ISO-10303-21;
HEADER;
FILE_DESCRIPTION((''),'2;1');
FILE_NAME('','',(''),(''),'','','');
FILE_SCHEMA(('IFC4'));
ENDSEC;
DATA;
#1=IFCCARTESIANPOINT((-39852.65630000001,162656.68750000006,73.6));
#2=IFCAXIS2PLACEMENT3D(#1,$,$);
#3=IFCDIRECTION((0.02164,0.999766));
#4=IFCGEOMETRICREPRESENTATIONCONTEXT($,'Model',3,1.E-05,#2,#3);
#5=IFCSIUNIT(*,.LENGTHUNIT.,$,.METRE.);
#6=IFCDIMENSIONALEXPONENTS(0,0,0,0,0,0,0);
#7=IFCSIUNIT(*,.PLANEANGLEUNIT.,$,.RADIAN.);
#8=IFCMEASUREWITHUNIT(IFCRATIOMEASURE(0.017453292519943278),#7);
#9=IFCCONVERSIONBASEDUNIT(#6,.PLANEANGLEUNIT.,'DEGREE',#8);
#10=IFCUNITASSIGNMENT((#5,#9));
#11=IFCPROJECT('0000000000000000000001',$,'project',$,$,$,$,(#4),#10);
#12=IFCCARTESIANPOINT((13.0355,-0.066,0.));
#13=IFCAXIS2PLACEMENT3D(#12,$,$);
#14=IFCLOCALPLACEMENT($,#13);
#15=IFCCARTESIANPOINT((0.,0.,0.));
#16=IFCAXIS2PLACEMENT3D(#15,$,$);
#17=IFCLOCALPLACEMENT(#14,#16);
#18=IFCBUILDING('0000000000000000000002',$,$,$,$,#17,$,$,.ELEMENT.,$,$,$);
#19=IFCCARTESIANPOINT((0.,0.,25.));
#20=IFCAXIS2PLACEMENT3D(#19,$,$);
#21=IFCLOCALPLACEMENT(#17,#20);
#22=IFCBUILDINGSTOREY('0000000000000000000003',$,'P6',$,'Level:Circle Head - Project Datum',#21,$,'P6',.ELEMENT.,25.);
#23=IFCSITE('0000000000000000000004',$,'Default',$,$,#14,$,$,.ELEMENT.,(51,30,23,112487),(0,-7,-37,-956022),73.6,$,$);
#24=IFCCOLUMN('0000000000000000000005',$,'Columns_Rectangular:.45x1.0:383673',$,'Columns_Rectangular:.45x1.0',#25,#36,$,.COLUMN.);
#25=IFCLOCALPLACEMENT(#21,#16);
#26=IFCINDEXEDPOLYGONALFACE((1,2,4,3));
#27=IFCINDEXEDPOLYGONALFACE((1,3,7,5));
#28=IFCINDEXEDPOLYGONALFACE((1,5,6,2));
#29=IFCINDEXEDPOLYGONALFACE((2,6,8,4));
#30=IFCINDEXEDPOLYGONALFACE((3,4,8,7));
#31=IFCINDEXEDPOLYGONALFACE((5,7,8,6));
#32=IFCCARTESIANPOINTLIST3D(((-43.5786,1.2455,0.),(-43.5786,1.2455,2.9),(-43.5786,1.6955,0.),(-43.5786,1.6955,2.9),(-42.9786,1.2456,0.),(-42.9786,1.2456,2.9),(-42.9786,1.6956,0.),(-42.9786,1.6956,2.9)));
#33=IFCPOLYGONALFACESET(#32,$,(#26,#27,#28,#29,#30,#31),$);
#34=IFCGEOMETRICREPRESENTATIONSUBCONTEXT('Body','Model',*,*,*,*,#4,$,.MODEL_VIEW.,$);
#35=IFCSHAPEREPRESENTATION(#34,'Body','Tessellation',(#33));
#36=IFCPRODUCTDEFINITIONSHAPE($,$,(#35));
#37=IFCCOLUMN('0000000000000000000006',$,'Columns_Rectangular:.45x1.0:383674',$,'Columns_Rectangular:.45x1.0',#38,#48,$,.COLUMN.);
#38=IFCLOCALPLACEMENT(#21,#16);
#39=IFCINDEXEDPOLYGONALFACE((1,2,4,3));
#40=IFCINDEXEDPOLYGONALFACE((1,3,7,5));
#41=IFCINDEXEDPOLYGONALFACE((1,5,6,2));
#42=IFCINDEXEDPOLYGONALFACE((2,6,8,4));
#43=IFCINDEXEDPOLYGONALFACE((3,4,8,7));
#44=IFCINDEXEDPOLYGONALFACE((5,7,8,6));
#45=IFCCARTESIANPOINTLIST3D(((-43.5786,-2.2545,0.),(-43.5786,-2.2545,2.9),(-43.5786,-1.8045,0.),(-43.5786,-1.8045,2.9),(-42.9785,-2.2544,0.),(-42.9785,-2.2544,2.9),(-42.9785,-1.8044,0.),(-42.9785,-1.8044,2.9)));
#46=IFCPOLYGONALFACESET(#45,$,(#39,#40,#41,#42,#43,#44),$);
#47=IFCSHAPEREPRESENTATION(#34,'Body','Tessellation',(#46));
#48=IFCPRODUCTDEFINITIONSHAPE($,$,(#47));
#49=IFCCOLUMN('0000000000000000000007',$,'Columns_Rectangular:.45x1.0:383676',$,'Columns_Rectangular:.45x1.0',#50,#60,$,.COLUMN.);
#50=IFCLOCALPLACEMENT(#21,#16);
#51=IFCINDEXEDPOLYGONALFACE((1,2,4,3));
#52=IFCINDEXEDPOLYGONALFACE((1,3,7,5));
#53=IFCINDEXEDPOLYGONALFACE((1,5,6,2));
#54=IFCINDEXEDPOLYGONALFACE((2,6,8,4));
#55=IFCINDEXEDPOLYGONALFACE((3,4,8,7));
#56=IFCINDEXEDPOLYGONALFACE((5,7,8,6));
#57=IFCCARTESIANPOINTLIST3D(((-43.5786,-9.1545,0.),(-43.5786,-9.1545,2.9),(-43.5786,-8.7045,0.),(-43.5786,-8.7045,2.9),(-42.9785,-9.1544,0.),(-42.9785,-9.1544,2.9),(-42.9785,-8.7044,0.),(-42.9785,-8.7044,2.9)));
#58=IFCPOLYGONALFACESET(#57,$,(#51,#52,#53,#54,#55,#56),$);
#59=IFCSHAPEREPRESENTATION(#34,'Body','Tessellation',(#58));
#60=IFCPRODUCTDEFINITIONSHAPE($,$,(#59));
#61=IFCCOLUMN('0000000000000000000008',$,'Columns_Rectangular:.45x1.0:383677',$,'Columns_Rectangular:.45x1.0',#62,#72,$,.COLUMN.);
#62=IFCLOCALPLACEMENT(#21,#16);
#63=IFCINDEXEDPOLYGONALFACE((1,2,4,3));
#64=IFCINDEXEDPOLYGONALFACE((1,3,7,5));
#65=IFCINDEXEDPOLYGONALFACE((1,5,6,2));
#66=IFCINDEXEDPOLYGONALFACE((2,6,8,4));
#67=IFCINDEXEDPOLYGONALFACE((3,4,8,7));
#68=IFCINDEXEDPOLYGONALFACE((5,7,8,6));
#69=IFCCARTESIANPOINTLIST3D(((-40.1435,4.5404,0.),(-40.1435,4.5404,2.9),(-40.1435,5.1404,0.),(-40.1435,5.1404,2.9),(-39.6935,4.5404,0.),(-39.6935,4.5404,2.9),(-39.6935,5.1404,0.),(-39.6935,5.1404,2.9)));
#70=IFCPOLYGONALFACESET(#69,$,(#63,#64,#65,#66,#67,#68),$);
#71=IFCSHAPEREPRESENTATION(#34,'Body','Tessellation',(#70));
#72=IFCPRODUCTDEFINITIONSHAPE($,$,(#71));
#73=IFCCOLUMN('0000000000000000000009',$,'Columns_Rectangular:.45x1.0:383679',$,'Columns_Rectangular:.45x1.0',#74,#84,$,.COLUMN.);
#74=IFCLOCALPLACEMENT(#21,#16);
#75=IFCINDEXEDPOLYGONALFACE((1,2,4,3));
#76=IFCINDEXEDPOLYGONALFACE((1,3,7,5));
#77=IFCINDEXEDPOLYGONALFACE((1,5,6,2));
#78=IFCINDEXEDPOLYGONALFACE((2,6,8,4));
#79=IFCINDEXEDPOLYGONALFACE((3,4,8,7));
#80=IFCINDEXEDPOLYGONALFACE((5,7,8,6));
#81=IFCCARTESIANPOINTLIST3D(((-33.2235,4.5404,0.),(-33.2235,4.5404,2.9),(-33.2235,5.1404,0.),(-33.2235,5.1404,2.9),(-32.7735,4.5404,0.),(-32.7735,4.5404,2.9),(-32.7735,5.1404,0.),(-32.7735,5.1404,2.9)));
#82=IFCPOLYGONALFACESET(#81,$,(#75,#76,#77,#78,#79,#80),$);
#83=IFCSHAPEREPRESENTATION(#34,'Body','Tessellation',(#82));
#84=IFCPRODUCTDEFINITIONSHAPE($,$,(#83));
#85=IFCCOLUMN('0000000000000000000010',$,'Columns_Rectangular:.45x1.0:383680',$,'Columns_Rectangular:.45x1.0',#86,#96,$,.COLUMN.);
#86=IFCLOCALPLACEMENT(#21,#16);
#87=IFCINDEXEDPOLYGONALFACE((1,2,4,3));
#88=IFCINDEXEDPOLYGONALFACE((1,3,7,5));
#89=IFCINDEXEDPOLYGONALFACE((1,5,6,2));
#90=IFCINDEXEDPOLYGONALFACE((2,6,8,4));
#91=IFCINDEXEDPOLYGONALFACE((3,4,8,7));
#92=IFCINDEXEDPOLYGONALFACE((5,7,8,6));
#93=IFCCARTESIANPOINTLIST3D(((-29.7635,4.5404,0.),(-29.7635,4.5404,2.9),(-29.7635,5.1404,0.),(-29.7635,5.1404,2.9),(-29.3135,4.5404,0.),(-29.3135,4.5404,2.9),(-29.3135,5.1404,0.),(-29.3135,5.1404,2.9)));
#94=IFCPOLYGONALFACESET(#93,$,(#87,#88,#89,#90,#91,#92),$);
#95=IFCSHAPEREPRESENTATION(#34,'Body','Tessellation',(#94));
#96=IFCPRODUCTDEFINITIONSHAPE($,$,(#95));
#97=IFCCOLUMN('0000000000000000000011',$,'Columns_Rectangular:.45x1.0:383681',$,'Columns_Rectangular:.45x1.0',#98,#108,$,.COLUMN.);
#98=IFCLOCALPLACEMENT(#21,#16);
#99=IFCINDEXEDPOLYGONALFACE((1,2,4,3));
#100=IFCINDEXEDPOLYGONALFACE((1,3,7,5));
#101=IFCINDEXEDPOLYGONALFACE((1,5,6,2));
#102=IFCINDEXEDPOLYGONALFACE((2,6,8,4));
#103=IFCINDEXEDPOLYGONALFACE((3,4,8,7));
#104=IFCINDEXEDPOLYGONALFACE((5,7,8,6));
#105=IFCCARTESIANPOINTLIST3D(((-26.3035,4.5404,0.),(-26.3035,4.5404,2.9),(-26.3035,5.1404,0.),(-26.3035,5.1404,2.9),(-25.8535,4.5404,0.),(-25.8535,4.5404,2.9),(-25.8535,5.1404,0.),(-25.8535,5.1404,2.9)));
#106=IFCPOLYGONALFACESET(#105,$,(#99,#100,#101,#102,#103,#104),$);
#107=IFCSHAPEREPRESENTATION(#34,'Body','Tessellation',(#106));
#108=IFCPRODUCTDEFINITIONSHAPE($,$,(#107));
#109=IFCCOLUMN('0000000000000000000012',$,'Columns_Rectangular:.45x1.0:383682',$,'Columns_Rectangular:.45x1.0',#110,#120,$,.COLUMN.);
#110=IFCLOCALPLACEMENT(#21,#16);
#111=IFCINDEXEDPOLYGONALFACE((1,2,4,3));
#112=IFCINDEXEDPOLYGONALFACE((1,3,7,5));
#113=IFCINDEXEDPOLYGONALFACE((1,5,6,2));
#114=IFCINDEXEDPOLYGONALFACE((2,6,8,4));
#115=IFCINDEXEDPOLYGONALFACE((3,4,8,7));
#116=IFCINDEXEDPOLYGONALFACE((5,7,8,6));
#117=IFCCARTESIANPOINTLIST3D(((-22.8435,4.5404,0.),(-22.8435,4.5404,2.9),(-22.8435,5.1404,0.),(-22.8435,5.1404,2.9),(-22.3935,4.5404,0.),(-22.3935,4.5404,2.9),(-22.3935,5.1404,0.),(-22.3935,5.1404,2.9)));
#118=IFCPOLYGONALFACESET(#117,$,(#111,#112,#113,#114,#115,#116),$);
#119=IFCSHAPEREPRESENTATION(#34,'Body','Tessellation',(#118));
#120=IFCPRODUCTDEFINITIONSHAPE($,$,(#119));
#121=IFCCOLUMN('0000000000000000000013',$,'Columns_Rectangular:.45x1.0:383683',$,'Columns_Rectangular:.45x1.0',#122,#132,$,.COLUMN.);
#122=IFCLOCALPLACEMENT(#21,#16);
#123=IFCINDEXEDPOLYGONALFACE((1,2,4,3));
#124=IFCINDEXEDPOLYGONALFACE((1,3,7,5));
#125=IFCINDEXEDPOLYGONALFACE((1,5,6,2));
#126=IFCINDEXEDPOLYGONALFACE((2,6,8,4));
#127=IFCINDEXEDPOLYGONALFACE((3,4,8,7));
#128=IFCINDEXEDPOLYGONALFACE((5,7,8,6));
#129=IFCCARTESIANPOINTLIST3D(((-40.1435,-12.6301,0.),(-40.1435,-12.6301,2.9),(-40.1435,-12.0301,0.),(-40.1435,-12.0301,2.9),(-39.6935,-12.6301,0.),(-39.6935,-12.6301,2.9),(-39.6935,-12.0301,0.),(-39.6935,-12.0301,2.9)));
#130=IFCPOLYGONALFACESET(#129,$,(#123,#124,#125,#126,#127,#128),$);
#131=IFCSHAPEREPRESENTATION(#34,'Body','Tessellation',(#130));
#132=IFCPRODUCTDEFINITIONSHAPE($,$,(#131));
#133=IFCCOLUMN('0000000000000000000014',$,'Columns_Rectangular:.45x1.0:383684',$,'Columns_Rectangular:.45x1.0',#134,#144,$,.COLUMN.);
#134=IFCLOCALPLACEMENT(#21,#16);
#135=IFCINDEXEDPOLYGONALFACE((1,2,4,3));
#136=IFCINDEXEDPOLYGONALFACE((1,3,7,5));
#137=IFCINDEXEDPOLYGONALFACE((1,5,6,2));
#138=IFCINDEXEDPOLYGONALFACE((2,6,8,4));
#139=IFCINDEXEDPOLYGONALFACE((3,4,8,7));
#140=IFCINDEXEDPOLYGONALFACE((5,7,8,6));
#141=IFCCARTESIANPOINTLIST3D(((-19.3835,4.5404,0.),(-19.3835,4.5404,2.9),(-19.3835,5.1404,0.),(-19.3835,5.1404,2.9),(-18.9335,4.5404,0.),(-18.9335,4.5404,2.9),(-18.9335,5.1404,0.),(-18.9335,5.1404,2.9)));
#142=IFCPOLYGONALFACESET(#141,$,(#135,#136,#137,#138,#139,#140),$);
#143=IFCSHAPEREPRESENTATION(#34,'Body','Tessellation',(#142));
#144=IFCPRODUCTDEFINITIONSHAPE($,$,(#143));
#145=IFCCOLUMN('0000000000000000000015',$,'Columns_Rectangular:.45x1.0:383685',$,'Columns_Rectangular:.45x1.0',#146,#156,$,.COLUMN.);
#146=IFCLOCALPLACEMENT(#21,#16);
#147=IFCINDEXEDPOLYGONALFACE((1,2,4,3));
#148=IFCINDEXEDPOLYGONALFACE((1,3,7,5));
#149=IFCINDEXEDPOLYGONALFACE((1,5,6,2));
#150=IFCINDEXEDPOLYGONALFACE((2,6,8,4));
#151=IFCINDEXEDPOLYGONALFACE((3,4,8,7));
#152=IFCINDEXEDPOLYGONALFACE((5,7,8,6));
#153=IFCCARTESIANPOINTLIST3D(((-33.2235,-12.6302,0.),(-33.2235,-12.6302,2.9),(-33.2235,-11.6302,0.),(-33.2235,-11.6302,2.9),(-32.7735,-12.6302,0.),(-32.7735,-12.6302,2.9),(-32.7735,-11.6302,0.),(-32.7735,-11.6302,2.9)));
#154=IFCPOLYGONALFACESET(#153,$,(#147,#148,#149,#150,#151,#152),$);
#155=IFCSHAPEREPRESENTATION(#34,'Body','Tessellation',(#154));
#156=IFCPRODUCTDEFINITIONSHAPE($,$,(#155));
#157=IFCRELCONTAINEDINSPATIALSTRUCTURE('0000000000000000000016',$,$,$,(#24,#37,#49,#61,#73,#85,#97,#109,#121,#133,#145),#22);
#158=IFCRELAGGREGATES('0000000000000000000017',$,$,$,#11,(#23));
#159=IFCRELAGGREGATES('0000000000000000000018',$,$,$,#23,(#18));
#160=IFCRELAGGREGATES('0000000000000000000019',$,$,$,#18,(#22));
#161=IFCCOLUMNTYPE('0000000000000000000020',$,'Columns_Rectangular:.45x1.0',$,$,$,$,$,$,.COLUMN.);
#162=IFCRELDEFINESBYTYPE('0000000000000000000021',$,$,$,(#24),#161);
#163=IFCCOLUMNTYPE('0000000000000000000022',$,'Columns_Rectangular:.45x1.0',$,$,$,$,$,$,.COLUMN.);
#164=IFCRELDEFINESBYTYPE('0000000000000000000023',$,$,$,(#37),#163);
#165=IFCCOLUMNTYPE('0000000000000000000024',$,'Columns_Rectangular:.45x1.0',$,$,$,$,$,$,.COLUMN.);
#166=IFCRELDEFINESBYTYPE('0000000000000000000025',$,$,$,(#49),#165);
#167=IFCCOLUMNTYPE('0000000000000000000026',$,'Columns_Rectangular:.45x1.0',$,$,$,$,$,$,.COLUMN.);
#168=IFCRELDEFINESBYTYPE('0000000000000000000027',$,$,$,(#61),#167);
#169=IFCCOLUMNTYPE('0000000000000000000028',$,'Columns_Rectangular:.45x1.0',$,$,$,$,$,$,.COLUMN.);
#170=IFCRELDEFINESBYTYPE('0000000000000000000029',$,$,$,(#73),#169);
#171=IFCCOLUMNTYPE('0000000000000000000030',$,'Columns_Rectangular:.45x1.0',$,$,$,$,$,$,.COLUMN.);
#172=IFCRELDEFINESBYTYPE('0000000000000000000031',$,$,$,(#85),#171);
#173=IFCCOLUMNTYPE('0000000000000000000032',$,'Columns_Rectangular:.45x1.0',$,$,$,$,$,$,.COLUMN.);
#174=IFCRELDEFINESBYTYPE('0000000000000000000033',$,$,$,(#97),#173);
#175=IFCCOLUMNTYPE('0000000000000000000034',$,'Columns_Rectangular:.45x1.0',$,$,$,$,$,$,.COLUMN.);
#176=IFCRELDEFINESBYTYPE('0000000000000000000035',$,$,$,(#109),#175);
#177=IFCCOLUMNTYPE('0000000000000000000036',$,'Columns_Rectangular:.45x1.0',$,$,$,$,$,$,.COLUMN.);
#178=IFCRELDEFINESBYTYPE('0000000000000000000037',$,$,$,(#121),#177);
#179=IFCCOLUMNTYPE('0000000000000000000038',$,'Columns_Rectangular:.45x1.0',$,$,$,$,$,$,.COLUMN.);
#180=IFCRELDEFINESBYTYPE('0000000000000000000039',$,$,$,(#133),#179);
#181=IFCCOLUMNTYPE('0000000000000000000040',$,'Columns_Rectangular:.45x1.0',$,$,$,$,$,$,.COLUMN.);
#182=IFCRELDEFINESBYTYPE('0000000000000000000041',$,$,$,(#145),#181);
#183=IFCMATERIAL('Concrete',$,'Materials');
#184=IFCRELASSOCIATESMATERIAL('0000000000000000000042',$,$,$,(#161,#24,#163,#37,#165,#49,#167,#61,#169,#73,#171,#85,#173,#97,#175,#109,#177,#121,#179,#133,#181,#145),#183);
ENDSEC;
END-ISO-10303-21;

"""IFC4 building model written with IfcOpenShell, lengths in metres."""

from ifc_helpers import new_model, entity, si_unit, converted_unit, direction, frame, origin, place, context, subcontext, project, spatial, indexed_curve, outline, extrude, source, transform, mapped, material, type_object, type_shapes, element, save


model = new_model("IFC4")

# Units and contexts
model_context = context("Model", 3, precision=1e-05, world=frame((-39852.65630000001, 162656.68750000006, 73.6)), true_north=direction((0.02164, 0.999766)))
body_context = subcontext(model_context, "Body", "Model", "MODEL_VIEW")
ifc_project = project(units=[si_unit("LENGTHUNIT", "METRE"), converted_unit("PLANEANGLEUNIT", "DEGREE", entity("IfcRatioMeasure", 0.017453292519943278), si_unit("PLANEANGLEUNIT", "RADIAN"), dimensions=[0, 0, 0, 0, 0, 0, 0])], contexts=[model_context])

# Site, building, storey
site_placement = place(None, frame((13.0355, -0.066, 0.0)))
site = spatial("IfcSite", under=ifc_project, at=site_placement, Name="Default", CompositionType="ELEMENT", RefLatitude=(51, 30, 23, 112487), RefLongitude=(0, -7, -37, -956022), RefElevation=73.6)
building_placement = place(site_placement, origin())
building = spatial("IfcBuilding", under=site, at=building_placement, CompositionType="ELEMENT")
storey_placement = place(building_placement, frame((0.0, 0.0, 25.0)))
storey = spatial("IfcBuildingStorey", under=building, at=storey_placement, Name="P6", ObjectType="Level:Circle Head - Project Datum", LongName="P6", CompositionType="ELEMENT", Elevation=25.0)

# Columns
ifc_material = material(Name="Concrete", Category="Materials")
column_type_1 = type_object("IfcColumnType", Name="Columns_Rectangular:.45x1.0", PredefinedType="COLUMN", material=ifc_material)
shared_shape_1 = source(origin(), body_context, "Body", "SweptSolid", [
    extrude(outline(indexed_curve([(-0.3, -0.225), (0.3, -0.225), (0.3, 0.225), (-0.3, 0.225), (-0.3, -0.225)], self_intersect=False)), frame((-43.2786, 1.4706, 25.0), z_axis=(0.0, 0.0, 1.0), x_axis=(-1.0, -0.000005, 0.0)), (0.0, 0.0, 1.0), 2.9),
])
type_shapes(column_type_1, [shared_shape_1])
column_1_placement = place(storey_placement, frame((0.0, 0.0, -25.0)))
element("IfcColumn", 1, at=column_1_placement, inside=storey, type_object=column_type_1, material=ifc_material, Name="Columns_Rectangular:.45x1.0:383673", ObjectType="Columns_Rectangular:.45x1.0", PredefinedType="COLUMN", context=body_context, shape_type="MappedRepresentation", body=[
    mapped(shared_shape_1, transform((0.0, 0.0, 0.0), scale=1.0)),
])
column_type_2 = type_object("IfcColumnType", Name="Columns_Rectangular:.45x1.0", PredefinedType="COLUMN", material=ifc_material)
shared_shape_2 = source(origin(), body_context, "Body", "SweptSolid", [
    extrude(outline(indexed_curve([(-0.3, -0.225), (0.3, -0.225), (0.3, 0.225), (-0.3, 0.225), (-0.3, -0.225)], self_intersect=False)), frame((-43.2785, -2.0294, 25.0), z_axis=(0.0, 0.0, 1.0), x_axis=(-1.0, -0.000005, 0.0)), (0.0, 0.0, 1.0), 2.9),
])
type_shapes(column_type_2, [shared_shape_2])
column_2_placement = place(storey_placement, frame((0.0, 0.0, -25.0)))
element("IfcColumn", 2, at=column_2_placement, inside=storey, type_object=column_type_2, material=ifc_material, Name="Columns_Rectangular:.45x1.0:383674", ObjectType="Columns_Rectangular:.45x1.0", PredefinedType="COLUMN", context=body_context, shape_type="MappedRepresentation", body=[
    mapped(shared_shape_2, transform((0.0, 0.0, 0.0), scale=1.0)),
])
column_type_3 = type_object("IfcColumnType", Name="Columns_Rectangular:.45x1.0", PredefinedType="COLUMN", material=ifc_material)
shared_shape_3 = source(origin(), body_context, "Body", "SweptSolid", [
    extrude(outline(indexed_curve([(-0.3, -0.225), (0.3, -0.225), (0.3, 0.225), (-0.3, 0.225), (-0.3, -0.225)], self_intersect=False)), frame((-43.2785, -8.9294, 25.0), z_axis=(0.0, 0.0, 1.0), x_axis=(-1.0, -0.000005, 0.0)), (0.0, 0.0, 1.0), 2.9),
])
type_shapes(column_type_3, [shared_shape_3])
column_3_placement = place(storey_placement, frame((0.0, 0.0, -25.0)))
element("IfcColumn", 3, at=column_3_placement, inside=storey, type_object=column_type_3, material=ifc_material, Name="Columns_Rectangular:.45x1.0:383676", ObjectType="Columns_Rectangular:.45x1.0", PredefinedType="COLUMN", context=body_context, shape_type="MappedRepresentation", body=[
    mapped(shared_shape_3, transform((0.0, 0.0, 0.0), scale=1.0)),
])
column_type_4 = type_object("IfcColumnType", Name="Columns_Rectangular:.45x1.0", PredefinedType="COLUMN", material=ifc_material)
shared_shape_4 = source(origin(), body_context, "Body", "SweptSolid", [
    extrude(outline(indexed_curve([(-0.3, -0.225), (0.3, -0.225), (0.3, 0.225), (-0.3, 0.225), (-0.3, -0.225)], self_intersect=False)), frame((-39.9185, 4.8404, 25.0), z_axis=(0.0, 0.0, 1.0), x_axis=(0.0, -1.0, 0.0)), (0.0, 0.0, 1.0), 2.9),
])
type_shapes(column_type_4, [shared_shape_4])
column_4_placement = place(storey_placement, frame((0.0, 0.0, -25.0)))
element("IfcColumn", 4, at=column_4_placement, inside=storey, type_object=column_type_4, material=ifc_material, Name="Columns_Rectangular:.45x1.0:383677", ObjectType="Columns_Rectangular:.45x1.0", PredefinedType="COLUMN", context=body_context, shape_type="MappedRepresentation", body=[
    mapped(shared_shape_4, transform((0.0, 0.0, 0.0), scale=1.0)),
])
column_type_5 = type_object("IfcColumnType", Name="Columns_Rectangular:.45x1.0", PredefinedType="COLUMN", material=ifc_material)
shared_shape_5 = source(origin(), body_context, "Body", "SweptSolid", [
    extrude(outline(indexed_curve([(-0.3, -0.225), (0.3, -0.225), (0.3, 0.225), (-0.3, 0.225), (-0.3, -0.225)], self_intersect=False)), frame((-32.9985, 4.8404, 25.0), z_axis=(0.0, 0.0, 1.0), x_axis=(0.0, -1.0, 0.0)), (0.0, 0.0, 1.0), 2.9),
])
type_shapes(column_type_5, [shared_shape_5])
column_5_placement = place(storey_placement, frame((0.0, 0.0, -25.0)))
element("IfcColumn", 5, at=column_5_placement, inside=storey, type_object=column_type_5, material=ifc_material, Name="Columns_Rectangular:.45x1.0:383679", ObjectType="Columns_Rectangular:.45x1.0", PredefinedType="COLUMN", context=body_context, shape_type="MappedRepresentation", body=[
    mapped(shared_shape_5, transform((0.0, 0.0, 0.0), scale=1.0)),
])
column_type_6 = type_object("IfcColumnType", Name="Columns_Rectangular:.45x1.0", PredefinedType="COLUMN", material=ifc_material)
shared_shape_6 = source(origin(), body_context, "Body", "SweptSolid", [
    extrude(outline(indexed_curve([(-0.3, -0.225), (0.3, -0.225), (0.3, 0.225), (-0.3, 0.225), (-0.3, -0.225)], self_intersect=False)), frame((-29.5385, 4.8404, 25.0), z_axis=(0.0, 0.0, 1.0), x_axis=(0.0, -1.0, 0.0)), (0.0, 0.0, 1.0), 2.9),
])
type_shapes(column_type_6, [shared_shape_6])
column_6_placement = place(storey_placement, frame((0.0, 0.0, -25.0)))
element("IfcColumn", 6, at=column_6_placement, inside=storey, type_object=column_type_6, material=ifc_material, Name="Columns_Rectangular:.45x1.0:383680", ObjectType="Columns_Rectangular:.45x1.0", PredefinedType="COLUMN", context=body_context, shape_type="MappedRepresentation", body=[
    mapped(shared_shape_6, transform((0.0, 0.0, 0.0), scale=1.0)),
])
column_type_7 = type_object("IfcColumnType", Name="Columns_Rectangular:.45x1.0", PredefinedType="COLUMN", material=ifc_material)
shared_shape_7 = source(origin(), body_context, "Body", "SweptSolid", [
    extrude(outline(indexed_curve([(-0.3, -0.225), (0.3, -0.225), (0.3, 0.225), (-0.3, 0.225), (-0.3, -0.225)], self_intersect=False)), frame((-26.0785, 4.8404, 25.0), z_axis=(0.0, 0.0, 1.0), x_axis=(0.0, -1.0, 0.0)), (0.0, 0.0, 1.0), 2.9),
])
type_shapes(column_type_7, [shared_shape_7])
column_7_placement = place(storey_placement, frame((0.0, 0.0, -25.0)))
element("IfcColumn", 7, at=column_7_placement, inside=storey, type_object=column_type_7, material=ifc_material, Name="Columns_Rectangular:.45x1.0:383681", ObjectType="Columns_Rectangular:.45x1.0", PredefinedType="COLUMN", context=body_context, shape_type="MappedRepresentation", body=[
    mapped(shared_shape_7, transform((0.0, 0.0, 0.0), scale=1.0)),
])
column_type_8 = type_object("IfcColumnType", Name="Columns_Rectangular:.45x1.0", PredefinedType="COLUMN", material=ifc_material)
shared_shape_8 = source(origin(), body_context, "Body", "SweptSolid", [
    extrude(outline(indexed_curve([(-0.3, -0.225), (0.3, -0.225), (0.3, 0.225), (-0.3, 0.225), (-0.3, -0.225)], self_intersect=False)), frame((-22.6185, 4.8404, 25.0), z_axis=(0.0, 0.0, 1.0), x_axis=(0.0, -1.0, 0.0)), (0.0, 0.0, 1.0), 2.9),
])
type_shapes(column_type_8, [shared_shape_8])
column_8_placement = place(storey_placement, frame((0.0, 0.0, -25.0)))
element("IfcColumn", 8, at=column_8_placement, inside=storey, type_object=column_type_8, material=ifc_material, Name="Columns_Rectangular:.45x1.0:383682", ObjectType="Columns_Rectangular:.45x1.0", PredefinedType="COLUMN", context=body_context, shape_type="MappedRepresentation", body=[
    mapped(shared_shape_8, transform((0.0, 0.0, 0.0), scale=1.0)),
])
column_type_9 = type_object("IfcColumnType", Name="Columns_Rectangular:.45x1.0", PredefinedType="COLUMN", material=ifc_material)
shared_shape_9 = source(origin(), body_context, "Body", "SweptSolid", [
    extrude(outline(indexed_curve([(-0.3, -0.225), (0.3, -0.225), (0.3, 0.225), (-0.3, 0.225), (-0.3, -0.225)], self_intersect=False)), frame((-39.9185, -12.3301, 25.0), z_axis=(0.0, 0.0, 1.0), x_axis=(0.000011, 1.0, 0.0)), (0.0, 0.0, 1.0), 2.9),
])
type_shapes(column_type_9, [shared_shape_9])
column_9_placement = place(storey_placement, frame((0.0, 0.0, -25.0)))
element("IfcColumn", 9, at=column_9_placement, inside=storey, type_object=column_type_9, material=ifc_material, Name="Columns_Rectangular:.45x1.0:383683", ObjectType="Columns_Rectangular:.45x1.0", PredefinedType="COLUMN", context=body_context, shape_type="MappedRepresentation", body=[
    mapped(shared_shape_9, transform((0.0, 0.0, 0.0), scale=1.0)),
])
column_type_10 = type_object("IfcColumnType", Name="Columns_Rectangular:.45x1.0", PredefinedType="COLUMN", material=ifc_material)
shared_shape_10 = source(origin(), body_context, "Body", "SweptSolid", [
    extrude(outline(indexed_curve([(-0.3, -0.225), (0.3, -0.225), (0.3, 0.225), (-0.3, 0.225), (-0.3, -0.225)], self_intersect=False)), frame((-19.1585, 4.8404, 25.0), z_axis=(0.0, 0.0, 1.0), x_axis=(0.0, -1.0, 0.0)), (0.0, 0.0, 1.0), 2.9),
])
type_shapes(column_type_10, [shared_shape_10])
column_10_placement = place(storey_placement, frame((0.0, 0.0, -25.0)))
element("IfcColumn", 10, at=column_10_placement, inside=storey, type_object=column_type_10, material=ifc_material, Name="Columns_Rectangular:.45x1.0:383684", ObjectType="Columns_Rectangular:.45x1.0", PredefinedType="COLUMN", context=body_context, shape_type="MappedRepresentation", body=[
    mapped(shared_shape_10, transform((0.0, 0.0, 0.0), scale=1.0)),
])
column_type_11 = type_object("IfcColumnType", Name="Columns_Rectangular:.45x1.0", PredefinedType="COLUMN", material=ifc_material)
shared_shape_11 = source(origin(), body_context, "Body", "SweptSolid", [
    extrude(outline(indexed_curve([(-0.5, -0.225), (0.5, -0.225), (0.5, 0.225), (-0.5, 0.225), (-0.5, -0.225)], self_intersect=False)), frame((-32.9985, -12.1302, 25.0), z_axis=(0.0, 0.0, 1.0), x_axis=(0.000011, 1.0, 0.0)), (0.0, 0.0, 1.0), 2.9),
])
type_shapes(column_type_11, [shared_shape_11])
column_11_placement = place(storey_placement, frame((0.0, 0.0, -25.0)))
element("IfcColumn", 11, at=column_11_placement, inside=storey, type_object=column_type_11, material=ifc_material, Name="Columns_Rectangular:.45x1.0:383685", ObjectType="Columns_Rectangular:.45x1.0", PredefinedType="COLUMN", context=body_context, shape_type="MappedRepresentation", body=[
    mapped(shared_shape_11, transform((0.0, 0.0, 0.0), scale=1.0)),
])

save(model, "model.ifc")
